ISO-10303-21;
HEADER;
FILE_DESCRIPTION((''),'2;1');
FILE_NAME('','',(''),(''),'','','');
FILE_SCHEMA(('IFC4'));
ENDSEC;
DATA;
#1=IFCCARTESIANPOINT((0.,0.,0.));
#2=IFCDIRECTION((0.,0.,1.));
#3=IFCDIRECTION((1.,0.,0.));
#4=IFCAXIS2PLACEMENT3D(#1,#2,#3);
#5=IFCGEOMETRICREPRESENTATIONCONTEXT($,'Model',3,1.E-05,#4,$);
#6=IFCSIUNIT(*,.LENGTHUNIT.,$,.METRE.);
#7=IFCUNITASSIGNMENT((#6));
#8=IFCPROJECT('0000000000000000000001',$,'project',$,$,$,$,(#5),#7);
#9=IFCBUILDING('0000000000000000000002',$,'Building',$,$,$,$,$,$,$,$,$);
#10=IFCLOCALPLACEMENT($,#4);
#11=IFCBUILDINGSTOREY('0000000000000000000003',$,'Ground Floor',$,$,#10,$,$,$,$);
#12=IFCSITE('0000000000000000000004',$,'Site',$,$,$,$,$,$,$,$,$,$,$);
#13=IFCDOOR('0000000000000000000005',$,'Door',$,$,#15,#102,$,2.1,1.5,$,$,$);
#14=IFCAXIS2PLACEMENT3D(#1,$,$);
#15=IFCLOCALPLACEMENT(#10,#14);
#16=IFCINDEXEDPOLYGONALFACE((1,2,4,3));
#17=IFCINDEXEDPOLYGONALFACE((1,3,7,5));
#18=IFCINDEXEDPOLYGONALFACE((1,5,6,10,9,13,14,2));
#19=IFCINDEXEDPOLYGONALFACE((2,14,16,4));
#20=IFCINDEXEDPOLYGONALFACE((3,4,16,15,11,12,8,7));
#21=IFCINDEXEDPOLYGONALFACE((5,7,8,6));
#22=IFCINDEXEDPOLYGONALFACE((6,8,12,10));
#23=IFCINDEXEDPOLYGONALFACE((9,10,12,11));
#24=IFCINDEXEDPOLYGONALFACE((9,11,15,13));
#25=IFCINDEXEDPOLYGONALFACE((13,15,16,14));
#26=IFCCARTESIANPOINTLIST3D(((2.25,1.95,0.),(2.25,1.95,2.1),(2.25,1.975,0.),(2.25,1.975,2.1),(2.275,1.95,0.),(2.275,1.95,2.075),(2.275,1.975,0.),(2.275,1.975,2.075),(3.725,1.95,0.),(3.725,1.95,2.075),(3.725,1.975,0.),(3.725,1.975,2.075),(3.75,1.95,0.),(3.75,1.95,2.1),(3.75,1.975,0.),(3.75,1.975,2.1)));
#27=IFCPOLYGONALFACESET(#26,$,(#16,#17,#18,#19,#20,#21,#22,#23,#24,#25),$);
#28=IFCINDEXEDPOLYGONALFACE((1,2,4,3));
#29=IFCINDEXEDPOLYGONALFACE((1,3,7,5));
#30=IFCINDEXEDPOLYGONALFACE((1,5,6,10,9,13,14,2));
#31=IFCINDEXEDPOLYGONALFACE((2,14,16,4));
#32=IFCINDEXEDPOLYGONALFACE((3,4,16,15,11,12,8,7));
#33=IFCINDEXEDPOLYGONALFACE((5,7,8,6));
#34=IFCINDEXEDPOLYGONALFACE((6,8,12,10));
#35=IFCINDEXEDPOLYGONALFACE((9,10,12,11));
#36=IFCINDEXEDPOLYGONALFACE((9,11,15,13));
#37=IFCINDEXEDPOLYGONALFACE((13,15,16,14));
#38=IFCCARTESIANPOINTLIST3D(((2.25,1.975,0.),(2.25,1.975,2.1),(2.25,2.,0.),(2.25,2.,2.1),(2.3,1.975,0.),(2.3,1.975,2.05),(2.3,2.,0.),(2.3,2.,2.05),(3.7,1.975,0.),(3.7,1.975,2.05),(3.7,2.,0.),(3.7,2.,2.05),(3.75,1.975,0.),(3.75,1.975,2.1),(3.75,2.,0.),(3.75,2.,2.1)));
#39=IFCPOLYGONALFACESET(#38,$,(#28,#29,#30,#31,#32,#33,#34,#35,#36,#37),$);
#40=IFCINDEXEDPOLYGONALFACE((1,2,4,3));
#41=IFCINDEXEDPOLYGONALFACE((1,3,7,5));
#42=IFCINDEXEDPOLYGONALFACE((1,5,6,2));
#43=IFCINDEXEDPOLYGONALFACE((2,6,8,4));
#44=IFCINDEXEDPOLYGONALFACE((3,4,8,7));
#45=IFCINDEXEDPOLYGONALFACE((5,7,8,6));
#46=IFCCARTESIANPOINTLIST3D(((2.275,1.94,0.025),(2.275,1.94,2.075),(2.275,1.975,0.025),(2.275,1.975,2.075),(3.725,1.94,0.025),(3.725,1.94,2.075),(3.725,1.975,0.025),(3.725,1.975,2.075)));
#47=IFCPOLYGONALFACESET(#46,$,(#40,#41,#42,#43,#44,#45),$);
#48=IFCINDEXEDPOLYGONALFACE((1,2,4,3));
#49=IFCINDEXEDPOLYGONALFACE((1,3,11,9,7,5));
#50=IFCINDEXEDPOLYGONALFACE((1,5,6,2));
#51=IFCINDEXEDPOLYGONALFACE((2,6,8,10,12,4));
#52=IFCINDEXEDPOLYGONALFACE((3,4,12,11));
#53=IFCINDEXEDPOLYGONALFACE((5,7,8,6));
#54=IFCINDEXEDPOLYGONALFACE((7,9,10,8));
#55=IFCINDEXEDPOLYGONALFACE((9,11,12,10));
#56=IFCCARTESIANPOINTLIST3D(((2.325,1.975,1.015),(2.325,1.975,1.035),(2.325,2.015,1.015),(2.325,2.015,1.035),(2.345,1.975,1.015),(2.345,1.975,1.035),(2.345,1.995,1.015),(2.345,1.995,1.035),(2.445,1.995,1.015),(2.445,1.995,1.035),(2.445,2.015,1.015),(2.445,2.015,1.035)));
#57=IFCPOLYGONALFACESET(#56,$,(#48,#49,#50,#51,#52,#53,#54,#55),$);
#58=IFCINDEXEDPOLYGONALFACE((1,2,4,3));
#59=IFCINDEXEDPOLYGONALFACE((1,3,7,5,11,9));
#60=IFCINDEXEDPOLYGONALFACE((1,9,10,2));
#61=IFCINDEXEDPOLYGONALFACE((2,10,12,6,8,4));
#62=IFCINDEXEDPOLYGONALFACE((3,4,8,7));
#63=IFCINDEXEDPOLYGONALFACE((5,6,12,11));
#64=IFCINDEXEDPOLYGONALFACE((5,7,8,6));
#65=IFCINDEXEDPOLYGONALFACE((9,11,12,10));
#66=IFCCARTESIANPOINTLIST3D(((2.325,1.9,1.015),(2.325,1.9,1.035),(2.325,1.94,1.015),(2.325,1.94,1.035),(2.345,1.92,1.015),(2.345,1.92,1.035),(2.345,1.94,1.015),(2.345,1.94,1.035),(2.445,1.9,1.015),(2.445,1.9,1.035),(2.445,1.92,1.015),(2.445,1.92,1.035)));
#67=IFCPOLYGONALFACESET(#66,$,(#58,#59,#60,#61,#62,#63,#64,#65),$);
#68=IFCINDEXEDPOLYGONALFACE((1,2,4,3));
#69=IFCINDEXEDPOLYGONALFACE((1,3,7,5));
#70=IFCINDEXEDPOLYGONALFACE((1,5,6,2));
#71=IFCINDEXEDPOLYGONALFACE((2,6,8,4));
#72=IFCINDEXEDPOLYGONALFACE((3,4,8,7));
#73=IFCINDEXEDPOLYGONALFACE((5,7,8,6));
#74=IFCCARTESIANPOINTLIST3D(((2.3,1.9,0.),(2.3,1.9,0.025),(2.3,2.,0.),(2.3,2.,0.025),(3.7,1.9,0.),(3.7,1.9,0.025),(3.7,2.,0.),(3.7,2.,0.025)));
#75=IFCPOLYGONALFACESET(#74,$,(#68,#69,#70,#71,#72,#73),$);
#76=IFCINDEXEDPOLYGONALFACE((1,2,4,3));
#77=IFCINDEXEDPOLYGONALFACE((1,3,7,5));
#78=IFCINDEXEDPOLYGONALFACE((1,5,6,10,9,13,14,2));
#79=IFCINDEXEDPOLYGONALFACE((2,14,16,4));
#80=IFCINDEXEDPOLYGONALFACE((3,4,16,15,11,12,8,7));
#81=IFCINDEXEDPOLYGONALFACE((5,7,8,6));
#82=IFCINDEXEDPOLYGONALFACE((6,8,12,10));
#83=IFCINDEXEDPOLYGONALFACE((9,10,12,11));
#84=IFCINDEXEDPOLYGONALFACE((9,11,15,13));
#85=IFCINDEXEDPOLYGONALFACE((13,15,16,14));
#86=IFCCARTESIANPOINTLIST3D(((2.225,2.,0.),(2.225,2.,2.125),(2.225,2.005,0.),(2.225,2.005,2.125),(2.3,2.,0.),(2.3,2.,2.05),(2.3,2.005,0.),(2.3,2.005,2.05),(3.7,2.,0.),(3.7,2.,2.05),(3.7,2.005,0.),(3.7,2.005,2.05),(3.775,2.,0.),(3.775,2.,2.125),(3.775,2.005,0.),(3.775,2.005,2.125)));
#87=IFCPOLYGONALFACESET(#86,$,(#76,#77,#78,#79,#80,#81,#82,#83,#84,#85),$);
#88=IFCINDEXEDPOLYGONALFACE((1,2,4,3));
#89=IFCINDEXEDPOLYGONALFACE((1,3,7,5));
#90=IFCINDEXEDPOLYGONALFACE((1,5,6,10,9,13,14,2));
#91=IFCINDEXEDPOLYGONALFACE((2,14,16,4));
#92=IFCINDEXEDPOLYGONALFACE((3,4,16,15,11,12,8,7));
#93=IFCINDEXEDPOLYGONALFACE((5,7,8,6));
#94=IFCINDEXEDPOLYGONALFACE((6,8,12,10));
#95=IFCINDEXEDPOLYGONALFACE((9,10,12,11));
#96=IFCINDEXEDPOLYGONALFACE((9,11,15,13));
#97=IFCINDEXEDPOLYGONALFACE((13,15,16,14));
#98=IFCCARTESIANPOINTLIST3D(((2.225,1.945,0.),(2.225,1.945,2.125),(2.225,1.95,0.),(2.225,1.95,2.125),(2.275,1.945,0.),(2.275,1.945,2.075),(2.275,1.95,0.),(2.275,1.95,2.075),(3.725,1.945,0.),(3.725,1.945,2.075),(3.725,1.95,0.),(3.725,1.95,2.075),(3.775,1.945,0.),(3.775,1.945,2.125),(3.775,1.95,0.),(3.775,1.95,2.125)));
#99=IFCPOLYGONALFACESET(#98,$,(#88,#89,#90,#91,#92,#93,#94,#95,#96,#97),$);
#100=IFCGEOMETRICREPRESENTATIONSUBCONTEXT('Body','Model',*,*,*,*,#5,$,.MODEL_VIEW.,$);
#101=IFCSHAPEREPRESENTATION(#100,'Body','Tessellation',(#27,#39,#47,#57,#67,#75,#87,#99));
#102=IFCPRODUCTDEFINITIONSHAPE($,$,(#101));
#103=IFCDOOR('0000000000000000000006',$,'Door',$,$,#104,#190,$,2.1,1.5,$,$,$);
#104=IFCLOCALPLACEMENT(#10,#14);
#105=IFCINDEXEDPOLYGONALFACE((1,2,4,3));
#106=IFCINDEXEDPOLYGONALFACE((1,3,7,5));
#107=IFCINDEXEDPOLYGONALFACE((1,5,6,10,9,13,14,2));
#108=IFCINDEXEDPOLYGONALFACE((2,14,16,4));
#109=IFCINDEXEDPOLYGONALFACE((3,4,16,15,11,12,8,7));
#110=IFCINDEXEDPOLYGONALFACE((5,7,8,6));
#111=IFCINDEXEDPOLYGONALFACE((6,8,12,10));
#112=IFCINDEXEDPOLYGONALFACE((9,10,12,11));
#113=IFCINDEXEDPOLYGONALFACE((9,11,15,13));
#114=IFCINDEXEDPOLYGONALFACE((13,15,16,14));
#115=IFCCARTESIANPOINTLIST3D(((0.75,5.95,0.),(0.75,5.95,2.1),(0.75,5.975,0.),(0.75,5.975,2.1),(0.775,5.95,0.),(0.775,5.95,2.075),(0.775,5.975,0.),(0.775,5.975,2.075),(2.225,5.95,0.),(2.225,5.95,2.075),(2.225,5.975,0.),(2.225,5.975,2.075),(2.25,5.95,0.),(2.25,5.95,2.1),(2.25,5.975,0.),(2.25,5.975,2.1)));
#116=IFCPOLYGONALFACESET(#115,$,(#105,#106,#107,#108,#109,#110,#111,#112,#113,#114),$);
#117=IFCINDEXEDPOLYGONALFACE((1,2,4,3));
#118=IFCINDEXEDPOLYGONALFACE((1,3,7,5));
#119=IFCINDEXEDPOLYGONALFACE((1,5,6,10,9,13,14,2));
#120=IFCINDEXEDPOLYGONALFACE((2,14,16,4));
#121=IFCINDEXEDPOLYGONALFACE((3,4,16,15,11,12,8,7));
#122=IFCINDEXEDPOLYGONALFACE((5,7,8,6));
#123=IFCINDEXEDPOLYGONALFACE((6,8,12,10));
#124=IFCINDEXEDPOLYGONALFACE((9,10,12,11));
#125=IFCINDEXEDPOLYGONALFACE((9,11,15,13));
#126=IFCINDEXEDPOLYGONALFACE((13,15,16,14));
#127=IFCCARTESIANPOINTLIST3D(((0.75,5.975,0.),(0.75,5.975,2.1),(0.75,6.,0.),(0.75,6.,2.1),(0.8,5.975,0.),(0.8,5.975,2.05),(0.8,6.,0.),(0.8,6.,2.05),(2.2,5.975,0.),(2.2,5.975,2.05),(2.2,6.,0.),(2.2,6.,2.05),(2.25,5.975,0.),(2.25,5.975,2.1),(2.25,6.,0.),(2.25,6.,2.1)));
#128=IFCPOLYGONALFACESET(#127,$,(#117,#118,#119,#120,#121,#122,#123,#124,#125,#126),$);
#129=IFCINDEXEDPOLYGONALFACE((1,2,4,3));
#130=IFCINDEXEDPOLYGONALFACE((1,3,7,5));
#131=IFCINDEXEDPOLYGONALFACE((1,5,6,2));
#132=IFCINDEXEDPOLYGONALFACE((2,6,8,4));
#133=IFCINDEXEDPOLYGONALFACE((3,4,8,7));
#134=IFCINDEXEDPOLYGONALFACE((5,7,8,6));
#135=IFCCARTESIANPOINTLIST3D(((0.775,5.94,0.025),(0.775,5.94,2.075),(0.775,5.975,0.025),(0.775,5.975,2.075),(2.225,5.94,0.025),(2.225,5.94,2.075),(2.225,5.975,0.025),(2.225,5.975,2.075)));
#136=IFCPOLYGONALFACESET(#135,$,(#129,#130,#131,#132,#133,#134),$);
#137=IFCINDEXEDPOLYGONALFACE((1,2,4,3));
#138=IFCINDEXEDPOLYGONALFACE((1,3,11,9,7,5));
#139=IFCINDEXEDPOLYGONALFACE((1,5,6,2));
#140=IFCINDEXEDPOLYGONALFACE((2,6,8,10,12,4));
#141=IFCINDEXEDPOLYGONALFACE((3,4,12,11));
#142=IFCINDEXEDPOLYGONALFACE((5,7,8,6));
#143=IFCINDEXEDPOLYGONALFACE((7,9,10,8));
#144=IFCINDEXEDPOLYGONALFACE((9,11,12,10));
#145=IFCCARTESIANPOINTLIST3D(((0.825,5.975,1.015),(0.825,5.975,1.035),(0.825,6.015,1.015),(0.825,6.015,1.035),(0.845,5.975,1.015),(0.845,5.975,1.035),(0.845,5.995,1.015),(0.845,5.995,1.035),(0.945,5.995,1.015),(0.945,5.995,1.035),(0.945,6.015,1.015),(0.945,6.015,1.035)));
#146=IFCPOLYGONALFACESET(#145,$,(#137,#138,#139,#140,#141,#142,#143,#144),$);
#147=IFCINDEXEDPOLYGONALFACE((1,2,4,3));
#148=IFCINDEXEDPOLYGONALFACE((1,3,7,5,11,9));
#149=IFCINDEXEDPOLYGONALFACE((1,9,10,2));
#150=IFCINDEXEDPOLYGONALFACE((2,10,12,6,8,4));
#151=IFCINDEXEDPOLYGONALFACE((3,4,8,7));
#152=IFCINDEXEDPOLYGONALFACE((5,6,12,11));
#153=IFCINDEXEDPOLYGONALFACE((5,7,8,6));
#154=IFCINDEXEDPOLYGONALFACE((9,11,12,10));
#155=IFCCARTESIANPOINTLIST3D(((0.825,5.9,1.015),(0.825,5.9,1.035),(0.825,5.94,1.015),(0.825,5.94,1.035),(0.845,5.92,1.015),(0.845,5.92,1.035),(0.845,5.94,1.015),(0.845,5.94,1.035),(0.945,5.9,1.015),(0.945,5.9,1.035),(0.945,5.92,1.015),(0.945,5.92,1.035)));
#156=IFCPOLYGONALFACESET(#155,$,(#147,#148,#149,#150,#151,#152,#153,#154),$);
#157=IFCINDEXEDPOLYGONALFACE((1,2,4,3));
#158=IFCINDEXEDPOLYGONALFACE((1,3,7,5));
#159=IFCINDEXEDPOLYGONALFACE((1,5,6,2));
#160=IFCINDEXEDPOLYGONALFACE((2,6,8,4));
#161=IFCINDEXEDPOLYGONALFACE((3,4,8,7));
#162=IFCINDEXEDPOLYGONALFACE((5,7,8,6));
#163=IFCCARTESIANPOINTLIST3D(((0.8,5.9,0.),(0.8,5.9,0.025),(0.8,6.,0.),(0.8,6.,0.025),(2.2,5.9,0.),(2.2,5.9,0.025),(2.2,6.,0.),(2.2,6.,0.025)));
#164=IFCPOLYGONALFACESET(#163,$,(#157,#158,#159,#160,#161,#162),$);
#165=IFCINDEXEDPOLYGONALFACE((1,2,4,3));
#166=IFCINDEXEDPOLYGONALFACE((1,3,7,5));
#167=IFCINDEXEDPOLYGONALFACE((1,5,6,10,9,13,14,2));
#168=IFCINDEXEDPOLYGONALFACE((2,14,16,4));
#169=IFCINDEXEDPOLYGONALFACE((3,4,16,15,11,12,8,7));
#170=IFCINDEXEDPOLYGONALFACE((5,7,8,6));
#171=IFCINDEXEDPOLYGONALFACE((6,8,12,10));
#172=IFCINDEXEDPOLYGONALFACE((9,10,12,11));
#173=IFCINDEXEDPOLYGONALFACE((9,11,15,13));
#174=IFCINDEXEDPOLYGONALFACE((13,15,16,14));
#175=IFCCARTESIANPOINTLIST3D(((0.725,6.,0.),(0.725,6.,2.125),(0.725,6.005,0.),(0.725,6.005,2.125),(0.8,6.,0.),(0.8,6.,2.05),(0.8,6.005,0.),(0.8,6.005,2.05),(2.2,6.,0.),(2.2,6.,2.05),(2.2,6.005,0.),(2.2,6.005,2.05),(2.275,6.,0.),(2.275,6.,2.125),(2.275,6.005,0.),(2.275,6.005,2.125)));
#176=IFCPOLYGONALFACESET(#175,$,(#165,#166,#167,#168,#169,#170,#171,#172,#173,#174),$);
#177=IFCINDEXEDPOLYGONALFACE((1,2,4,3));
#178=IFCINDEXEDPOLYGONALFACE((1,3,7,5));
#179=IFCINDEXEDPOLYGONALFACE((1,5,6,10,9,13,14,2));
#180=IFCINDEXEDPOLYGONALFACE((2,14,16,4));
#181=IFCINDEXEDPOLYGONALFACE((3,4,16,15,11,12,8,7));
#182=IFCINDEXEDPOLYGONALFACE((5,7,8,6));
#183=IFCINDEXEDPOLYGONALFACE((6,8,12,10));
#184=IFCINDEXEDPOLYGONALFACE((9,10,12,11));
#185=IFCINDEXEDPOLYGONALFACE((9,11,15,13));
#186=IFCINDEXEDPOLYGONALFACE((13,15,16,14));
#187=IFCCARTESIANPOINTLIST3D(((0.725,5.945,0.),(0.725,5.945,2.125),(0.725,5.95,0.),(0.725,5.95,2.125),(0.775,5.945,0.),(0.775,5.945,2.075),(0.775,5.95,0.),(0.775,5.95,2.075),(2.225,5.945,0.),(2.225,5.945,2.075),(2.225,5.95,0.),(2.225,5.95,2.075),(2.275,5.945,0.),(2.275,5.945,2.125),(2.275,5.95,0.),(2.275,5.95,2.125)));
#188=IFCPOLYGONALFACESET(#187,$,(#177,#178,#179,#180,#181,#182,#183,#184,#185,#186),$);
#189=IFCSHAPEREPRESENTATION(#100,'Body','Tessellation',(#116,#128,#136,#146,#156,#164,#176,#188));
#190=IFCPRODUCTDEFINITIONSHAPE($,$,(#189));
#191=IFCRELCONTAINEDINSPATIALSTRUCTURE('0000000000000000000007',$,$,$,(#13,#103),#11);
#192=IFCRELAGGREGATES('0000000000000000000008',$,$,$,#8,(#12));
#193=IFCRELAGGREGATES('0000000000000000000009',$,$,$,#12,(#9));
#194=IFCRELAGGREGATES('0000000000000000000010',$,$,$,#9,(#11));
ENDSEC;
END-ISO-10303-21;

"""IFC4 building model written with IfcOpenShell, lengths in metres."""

from ifc_helpers import new_model, si_unit, frame, origin_with_axes, place, context, subcontext, project, spatial, line, indexed_curve, outline, extrude, element, save


model = new_model("IFC4")

# Units and contexts
model_context = context("Model", 3, precision=1e-05, world=origin_with_axes())
body_context = subcontext(model_context, "Body", "Model", "MODEL_VIEW")
ifc_project = project(units=[si_unit("LENGTHUNIT", "METRE")], contexts=[model_context])

# Site, building, storey
site = spatial("IfcSite", under=ifc_project, Name="Site")
building = spatial("IfcBuilding", under=site, Name="Building")
storey_placement = place(None, origin_with_axes())
storey = spatial("IfcBuildingStorey", under=building, at=storey_placement, Name="Ground Floor")

# Doors
door_1_placement = place(storey_placement, frame((3.75, 2.0, 0.0), z_axis=(0.0, 0.0, 1.0), x_axis=(-1.0, 0.0, 0.0)))
element("IfcDoor", 1, at=door_1_placement, inside=storey, Name="Door", OverallHeight=2.1, OverallWidth=1.5, context=body_context, shape_type="SweptSolid", body=[
    extrude(outline(indexed_curve([(0.0, 0.0), (0.0, 2.1), (1.5, 2.1), (1.5, 0.0), (1.475, 0.0), (1.475, 2.075), (0.025, 2.075), (0.025, 0.0)], segments=[line(1, 2, 3, 4, 5, 6, 7, 8, 1)])), frame((0.0, 0.025, 0.0), z_axis=(0.0, -1.0, 0.0), x_axis=(1.0, 0.0, 0.0)), (0.0, 0.0, -1.0), 0.025),
    extrude(outline(indexed_curve([(0.0, 0.0), (0.0, 2.1), (1.5, 2.1), (1.5, 0.0), (1.45, 0.0), (1.45, 2.05), (0.05, 2.05), (0.05, 0.0)], segments=[line(1, 2, 3, 4, 5, 6, 7, 8, 1)])), frame((0.0, 0.0, 0.0), z_axis=(0.0, -1.0, 0.0), x_axis=(1.0, 0.0, 0.0)), (0.0, 0.0, -1.0), 0.025),
    extrude(outline(indexed_curve([(0.0, 0.0), (1.45, 0.0), (1.45, 0.035), (0.0, 0.035)], segments=[line(1, 2, 3, 4, 1)])), frame((0.025, 0.025, 0.025), z_axis=(0.0, 0.0, 1.0), x_axis=(1.0, 0.0, 0.0)), (0.0, 0.0, 1.0), 2.05),
    extrude(outline(indexed_curve([(0.0, 0.0), (0.0, -0.04), (-0.12, -0.04), (-0.12, -0.02), (-0.02, -0.02), (-0.02, 0.0)], segments=[line(1, 2, 3, 4, 5, 6, 1)])), frame((1.425, 0.025, 1.015), z_axis=(0.0, 0.0, 1.0), x_axis=(1.0, 0.0, 0.0)), (0.0, 0.0, 1.0), 0.02),
    extrude(outline(indexed_curve([(0.0, 0.0), (0.0, 0.04), (-0.12, 0.04), (-0.12, 0.02), (-0.02, 0.02), (-0.02, 0.0)], segments=[line(1, 2, 3, 4, 5, 6, 1)])), frame((1.425, 0.06, 1.015), z_axis=(0.0, 0.0, 1.0), x_axis=(1.0, 0.0, 0.0)), (0.0, 0.0, 1.0), 0.02),
    extrude(outline(indexed_curve([(0.0, 0.0), (1.4, 0.0), (1.4, 0.1), (0.0, 0.1)], segments=[line(1, 2, 3, 4, 1)])), frame((0.05, 0.0, 0.0), z_axis=(0.0, 0.0, 1.0), x_axis=(1.0, 0.0, 0.0)), (0.0, 0.0, 1.0), 0.025),
    extrude(outline(indexed_curve([(0.0, 0.0), (0.0, 2.125), (1.55, 2.125), (1.55, 0.0), (1.475, 0.0), (1.475, 2.05), (0.075, 2.05), (0.075, 0.0)], segments=[line(1, 2, 3, 4, 5, 6, 7, 8, 1)])), frame((-0.025, -0.005, 0.0), z_axis=(0.0, -1.0, 0.0), x_axis=(1.0, 0.0, 0.0)), (0.0, 0.0, -1.0), 0.005),
    extrude(outline(indexed_curve([(0.0, 0.0), (0.0, 2.125), (1.55, 2.125), (1.55, 0.0), (1.5, 0.0), (1.5, 2.075), (0.05, 2.075), (0.05, 0.0)], segments=[line(1, 2, 3, 4, 5, 6, 7, 8, 1)])), frame((-0.025, 0.05, 0.0), z_axis=(0.0, -1.0, 0.0), x_axis=(1.0, 0.0, 0.0)), (0.0, 0.0, -1.0), 0.005),
])
door_2_placement = place(storey_placement, frame((2.25, 6.0, 0.0), z_axis=(0.0, 0.0, 1.0), x_axis=(-1.0, 0.0, 0.0)))
element("IfcDoor", 2, at=door_2_placement, inside=storey, Name="Door", OverallHeight=2.1, OverallWidth=1.5, context=body_context, shape_type="SweptSolid", body=[
    extrude(outline(indexed_curve([(0.0, 0.0), (0.0, 2.1), (1.5, 2.1), (1.5, 0.0), (1.475, 0.0), (1.475, 2.075), (0.025, 2.075), (0.025, 0.0)], segments=[line(1, 2, 3, 4, 5, 6, 7, 8, 1)])), frame((0.0, 0.025, 0.0), z_axis=(0.0, -1.0, 0.0), x_axis=(1.0, 0.0, 0.0)), (0.0, 0.0, -1.0), 0.025),
    extrude(outline(indexed_curve([(0.0, 0.0), (0.0, 2.1), (1.5, 2.1), (1.5, 0.0), (1.45, 0.0), (1.45, 2.05), (0.05, 2.05), (0.05, 0.0)], segments=[line(1, 2, 3, 4, 5, 6, 7, 8, 1)])), frame((0.0, 0.0, 0.0), z_axis=(0.0, -1.0, 0.0), x_axis=(1.0, 0.0, 0.0)), (0.0, 0.0, -1.0), 0.025),
    extrude(outline(indexed_curve([(0.0, 0.0), (1.45, 0.0), (1.45, 0.035), (0.0, 0.035)], segments=[line(1, 2, 3, 4, 1)])), frame((0.025, 0.025, 0.025), z_axis=(0.0, 0.0, 1.0), x_axis=(1.0, 0.0, 0.0)), (0.0, 0.0, 1.0), 2.05),
    extrude(outline(indexed_curve([(0.0, 0.0), (0.0, -0.04), (-0.12, -0.04), (-0.12, -0.02), (-0.02, -0.02), (-0.02, 0.0)], segments=[line(1, 2, 3, 4, 5, 6, 1)])), frame((1.425, 0.025, 1.015), z_axis=(0.0, 0.0, 1.0), x_axis=(1.0, 0.0, 0.0)), (0.0, 0.0, 1.0), 0.02),
    extrude(outline(indexed_curve([(0.0, 0.0), (0.0, 0.04), (-0.12, 0.04), (-0.12, 0.02), (-0.02, 0.02), (-0.02, 0.0)], segments=[line(1, 2, 3, 4, 5, 6, 1)])), frame((1.425, 0.06, 1.015), z_axis=(0.0, 0.0, 1.0), x_axis=(1.0, 0.0, 0.0)), (0.0, 0.0, 1.0), 0.02),
    extrude(outline(indexed_curve([(0.0, 0.0), (1.4, 0.0), (1.4, 0.1), (0.0, 0.1)], segments=[line(1, 2, 3, 4, 1)])), frame((0.05, 0.0, 0.0), z_axis=(0.0, 0.0, 1.0), x_axis=(1.0, 0.0, 0.0)), (0.0, 0.0, 1.0), 0.025),
    extrude(outline(indexed_curve([(0.0, 0.0), (0.0, 2.125), (1.55, 2.125), (1.55, 0.0), (1.475, 0.0), (1.475, 2.05), (0.075, 2.05), (0.075, 0.0)], segments=[line(1, 2, 3, 4, 5, 6, 7, 8, 1)])), frame((-0.025, -0.005, 0.0), z_axis=(0.0, -1.0, 0.0), x_axis=(1.0, 0.0, 0.0)), (0.0, 0.0, -1.0), 0.005),
    extrude(outline(indexed_curve([(0.0, 0.0), (0.0, 2.125), (1.55, 2.125), (1.55, 0.0), (1.5, 0.0), (1.5, 2.075), (0.05, 2.075), (0.05, 0.0)], segments=[line(1, 2, 3, 4, 5, 6, 7, 8, 1)])), frame((-0.025, 0.05, 0.0), z_axis=(0.0, -1.0, 0.0), x_axis=(1.0, 0.0, 0.0)), (0.0, 0.0, -1.0), 0.005),
])

save(model, "model.ifc")
